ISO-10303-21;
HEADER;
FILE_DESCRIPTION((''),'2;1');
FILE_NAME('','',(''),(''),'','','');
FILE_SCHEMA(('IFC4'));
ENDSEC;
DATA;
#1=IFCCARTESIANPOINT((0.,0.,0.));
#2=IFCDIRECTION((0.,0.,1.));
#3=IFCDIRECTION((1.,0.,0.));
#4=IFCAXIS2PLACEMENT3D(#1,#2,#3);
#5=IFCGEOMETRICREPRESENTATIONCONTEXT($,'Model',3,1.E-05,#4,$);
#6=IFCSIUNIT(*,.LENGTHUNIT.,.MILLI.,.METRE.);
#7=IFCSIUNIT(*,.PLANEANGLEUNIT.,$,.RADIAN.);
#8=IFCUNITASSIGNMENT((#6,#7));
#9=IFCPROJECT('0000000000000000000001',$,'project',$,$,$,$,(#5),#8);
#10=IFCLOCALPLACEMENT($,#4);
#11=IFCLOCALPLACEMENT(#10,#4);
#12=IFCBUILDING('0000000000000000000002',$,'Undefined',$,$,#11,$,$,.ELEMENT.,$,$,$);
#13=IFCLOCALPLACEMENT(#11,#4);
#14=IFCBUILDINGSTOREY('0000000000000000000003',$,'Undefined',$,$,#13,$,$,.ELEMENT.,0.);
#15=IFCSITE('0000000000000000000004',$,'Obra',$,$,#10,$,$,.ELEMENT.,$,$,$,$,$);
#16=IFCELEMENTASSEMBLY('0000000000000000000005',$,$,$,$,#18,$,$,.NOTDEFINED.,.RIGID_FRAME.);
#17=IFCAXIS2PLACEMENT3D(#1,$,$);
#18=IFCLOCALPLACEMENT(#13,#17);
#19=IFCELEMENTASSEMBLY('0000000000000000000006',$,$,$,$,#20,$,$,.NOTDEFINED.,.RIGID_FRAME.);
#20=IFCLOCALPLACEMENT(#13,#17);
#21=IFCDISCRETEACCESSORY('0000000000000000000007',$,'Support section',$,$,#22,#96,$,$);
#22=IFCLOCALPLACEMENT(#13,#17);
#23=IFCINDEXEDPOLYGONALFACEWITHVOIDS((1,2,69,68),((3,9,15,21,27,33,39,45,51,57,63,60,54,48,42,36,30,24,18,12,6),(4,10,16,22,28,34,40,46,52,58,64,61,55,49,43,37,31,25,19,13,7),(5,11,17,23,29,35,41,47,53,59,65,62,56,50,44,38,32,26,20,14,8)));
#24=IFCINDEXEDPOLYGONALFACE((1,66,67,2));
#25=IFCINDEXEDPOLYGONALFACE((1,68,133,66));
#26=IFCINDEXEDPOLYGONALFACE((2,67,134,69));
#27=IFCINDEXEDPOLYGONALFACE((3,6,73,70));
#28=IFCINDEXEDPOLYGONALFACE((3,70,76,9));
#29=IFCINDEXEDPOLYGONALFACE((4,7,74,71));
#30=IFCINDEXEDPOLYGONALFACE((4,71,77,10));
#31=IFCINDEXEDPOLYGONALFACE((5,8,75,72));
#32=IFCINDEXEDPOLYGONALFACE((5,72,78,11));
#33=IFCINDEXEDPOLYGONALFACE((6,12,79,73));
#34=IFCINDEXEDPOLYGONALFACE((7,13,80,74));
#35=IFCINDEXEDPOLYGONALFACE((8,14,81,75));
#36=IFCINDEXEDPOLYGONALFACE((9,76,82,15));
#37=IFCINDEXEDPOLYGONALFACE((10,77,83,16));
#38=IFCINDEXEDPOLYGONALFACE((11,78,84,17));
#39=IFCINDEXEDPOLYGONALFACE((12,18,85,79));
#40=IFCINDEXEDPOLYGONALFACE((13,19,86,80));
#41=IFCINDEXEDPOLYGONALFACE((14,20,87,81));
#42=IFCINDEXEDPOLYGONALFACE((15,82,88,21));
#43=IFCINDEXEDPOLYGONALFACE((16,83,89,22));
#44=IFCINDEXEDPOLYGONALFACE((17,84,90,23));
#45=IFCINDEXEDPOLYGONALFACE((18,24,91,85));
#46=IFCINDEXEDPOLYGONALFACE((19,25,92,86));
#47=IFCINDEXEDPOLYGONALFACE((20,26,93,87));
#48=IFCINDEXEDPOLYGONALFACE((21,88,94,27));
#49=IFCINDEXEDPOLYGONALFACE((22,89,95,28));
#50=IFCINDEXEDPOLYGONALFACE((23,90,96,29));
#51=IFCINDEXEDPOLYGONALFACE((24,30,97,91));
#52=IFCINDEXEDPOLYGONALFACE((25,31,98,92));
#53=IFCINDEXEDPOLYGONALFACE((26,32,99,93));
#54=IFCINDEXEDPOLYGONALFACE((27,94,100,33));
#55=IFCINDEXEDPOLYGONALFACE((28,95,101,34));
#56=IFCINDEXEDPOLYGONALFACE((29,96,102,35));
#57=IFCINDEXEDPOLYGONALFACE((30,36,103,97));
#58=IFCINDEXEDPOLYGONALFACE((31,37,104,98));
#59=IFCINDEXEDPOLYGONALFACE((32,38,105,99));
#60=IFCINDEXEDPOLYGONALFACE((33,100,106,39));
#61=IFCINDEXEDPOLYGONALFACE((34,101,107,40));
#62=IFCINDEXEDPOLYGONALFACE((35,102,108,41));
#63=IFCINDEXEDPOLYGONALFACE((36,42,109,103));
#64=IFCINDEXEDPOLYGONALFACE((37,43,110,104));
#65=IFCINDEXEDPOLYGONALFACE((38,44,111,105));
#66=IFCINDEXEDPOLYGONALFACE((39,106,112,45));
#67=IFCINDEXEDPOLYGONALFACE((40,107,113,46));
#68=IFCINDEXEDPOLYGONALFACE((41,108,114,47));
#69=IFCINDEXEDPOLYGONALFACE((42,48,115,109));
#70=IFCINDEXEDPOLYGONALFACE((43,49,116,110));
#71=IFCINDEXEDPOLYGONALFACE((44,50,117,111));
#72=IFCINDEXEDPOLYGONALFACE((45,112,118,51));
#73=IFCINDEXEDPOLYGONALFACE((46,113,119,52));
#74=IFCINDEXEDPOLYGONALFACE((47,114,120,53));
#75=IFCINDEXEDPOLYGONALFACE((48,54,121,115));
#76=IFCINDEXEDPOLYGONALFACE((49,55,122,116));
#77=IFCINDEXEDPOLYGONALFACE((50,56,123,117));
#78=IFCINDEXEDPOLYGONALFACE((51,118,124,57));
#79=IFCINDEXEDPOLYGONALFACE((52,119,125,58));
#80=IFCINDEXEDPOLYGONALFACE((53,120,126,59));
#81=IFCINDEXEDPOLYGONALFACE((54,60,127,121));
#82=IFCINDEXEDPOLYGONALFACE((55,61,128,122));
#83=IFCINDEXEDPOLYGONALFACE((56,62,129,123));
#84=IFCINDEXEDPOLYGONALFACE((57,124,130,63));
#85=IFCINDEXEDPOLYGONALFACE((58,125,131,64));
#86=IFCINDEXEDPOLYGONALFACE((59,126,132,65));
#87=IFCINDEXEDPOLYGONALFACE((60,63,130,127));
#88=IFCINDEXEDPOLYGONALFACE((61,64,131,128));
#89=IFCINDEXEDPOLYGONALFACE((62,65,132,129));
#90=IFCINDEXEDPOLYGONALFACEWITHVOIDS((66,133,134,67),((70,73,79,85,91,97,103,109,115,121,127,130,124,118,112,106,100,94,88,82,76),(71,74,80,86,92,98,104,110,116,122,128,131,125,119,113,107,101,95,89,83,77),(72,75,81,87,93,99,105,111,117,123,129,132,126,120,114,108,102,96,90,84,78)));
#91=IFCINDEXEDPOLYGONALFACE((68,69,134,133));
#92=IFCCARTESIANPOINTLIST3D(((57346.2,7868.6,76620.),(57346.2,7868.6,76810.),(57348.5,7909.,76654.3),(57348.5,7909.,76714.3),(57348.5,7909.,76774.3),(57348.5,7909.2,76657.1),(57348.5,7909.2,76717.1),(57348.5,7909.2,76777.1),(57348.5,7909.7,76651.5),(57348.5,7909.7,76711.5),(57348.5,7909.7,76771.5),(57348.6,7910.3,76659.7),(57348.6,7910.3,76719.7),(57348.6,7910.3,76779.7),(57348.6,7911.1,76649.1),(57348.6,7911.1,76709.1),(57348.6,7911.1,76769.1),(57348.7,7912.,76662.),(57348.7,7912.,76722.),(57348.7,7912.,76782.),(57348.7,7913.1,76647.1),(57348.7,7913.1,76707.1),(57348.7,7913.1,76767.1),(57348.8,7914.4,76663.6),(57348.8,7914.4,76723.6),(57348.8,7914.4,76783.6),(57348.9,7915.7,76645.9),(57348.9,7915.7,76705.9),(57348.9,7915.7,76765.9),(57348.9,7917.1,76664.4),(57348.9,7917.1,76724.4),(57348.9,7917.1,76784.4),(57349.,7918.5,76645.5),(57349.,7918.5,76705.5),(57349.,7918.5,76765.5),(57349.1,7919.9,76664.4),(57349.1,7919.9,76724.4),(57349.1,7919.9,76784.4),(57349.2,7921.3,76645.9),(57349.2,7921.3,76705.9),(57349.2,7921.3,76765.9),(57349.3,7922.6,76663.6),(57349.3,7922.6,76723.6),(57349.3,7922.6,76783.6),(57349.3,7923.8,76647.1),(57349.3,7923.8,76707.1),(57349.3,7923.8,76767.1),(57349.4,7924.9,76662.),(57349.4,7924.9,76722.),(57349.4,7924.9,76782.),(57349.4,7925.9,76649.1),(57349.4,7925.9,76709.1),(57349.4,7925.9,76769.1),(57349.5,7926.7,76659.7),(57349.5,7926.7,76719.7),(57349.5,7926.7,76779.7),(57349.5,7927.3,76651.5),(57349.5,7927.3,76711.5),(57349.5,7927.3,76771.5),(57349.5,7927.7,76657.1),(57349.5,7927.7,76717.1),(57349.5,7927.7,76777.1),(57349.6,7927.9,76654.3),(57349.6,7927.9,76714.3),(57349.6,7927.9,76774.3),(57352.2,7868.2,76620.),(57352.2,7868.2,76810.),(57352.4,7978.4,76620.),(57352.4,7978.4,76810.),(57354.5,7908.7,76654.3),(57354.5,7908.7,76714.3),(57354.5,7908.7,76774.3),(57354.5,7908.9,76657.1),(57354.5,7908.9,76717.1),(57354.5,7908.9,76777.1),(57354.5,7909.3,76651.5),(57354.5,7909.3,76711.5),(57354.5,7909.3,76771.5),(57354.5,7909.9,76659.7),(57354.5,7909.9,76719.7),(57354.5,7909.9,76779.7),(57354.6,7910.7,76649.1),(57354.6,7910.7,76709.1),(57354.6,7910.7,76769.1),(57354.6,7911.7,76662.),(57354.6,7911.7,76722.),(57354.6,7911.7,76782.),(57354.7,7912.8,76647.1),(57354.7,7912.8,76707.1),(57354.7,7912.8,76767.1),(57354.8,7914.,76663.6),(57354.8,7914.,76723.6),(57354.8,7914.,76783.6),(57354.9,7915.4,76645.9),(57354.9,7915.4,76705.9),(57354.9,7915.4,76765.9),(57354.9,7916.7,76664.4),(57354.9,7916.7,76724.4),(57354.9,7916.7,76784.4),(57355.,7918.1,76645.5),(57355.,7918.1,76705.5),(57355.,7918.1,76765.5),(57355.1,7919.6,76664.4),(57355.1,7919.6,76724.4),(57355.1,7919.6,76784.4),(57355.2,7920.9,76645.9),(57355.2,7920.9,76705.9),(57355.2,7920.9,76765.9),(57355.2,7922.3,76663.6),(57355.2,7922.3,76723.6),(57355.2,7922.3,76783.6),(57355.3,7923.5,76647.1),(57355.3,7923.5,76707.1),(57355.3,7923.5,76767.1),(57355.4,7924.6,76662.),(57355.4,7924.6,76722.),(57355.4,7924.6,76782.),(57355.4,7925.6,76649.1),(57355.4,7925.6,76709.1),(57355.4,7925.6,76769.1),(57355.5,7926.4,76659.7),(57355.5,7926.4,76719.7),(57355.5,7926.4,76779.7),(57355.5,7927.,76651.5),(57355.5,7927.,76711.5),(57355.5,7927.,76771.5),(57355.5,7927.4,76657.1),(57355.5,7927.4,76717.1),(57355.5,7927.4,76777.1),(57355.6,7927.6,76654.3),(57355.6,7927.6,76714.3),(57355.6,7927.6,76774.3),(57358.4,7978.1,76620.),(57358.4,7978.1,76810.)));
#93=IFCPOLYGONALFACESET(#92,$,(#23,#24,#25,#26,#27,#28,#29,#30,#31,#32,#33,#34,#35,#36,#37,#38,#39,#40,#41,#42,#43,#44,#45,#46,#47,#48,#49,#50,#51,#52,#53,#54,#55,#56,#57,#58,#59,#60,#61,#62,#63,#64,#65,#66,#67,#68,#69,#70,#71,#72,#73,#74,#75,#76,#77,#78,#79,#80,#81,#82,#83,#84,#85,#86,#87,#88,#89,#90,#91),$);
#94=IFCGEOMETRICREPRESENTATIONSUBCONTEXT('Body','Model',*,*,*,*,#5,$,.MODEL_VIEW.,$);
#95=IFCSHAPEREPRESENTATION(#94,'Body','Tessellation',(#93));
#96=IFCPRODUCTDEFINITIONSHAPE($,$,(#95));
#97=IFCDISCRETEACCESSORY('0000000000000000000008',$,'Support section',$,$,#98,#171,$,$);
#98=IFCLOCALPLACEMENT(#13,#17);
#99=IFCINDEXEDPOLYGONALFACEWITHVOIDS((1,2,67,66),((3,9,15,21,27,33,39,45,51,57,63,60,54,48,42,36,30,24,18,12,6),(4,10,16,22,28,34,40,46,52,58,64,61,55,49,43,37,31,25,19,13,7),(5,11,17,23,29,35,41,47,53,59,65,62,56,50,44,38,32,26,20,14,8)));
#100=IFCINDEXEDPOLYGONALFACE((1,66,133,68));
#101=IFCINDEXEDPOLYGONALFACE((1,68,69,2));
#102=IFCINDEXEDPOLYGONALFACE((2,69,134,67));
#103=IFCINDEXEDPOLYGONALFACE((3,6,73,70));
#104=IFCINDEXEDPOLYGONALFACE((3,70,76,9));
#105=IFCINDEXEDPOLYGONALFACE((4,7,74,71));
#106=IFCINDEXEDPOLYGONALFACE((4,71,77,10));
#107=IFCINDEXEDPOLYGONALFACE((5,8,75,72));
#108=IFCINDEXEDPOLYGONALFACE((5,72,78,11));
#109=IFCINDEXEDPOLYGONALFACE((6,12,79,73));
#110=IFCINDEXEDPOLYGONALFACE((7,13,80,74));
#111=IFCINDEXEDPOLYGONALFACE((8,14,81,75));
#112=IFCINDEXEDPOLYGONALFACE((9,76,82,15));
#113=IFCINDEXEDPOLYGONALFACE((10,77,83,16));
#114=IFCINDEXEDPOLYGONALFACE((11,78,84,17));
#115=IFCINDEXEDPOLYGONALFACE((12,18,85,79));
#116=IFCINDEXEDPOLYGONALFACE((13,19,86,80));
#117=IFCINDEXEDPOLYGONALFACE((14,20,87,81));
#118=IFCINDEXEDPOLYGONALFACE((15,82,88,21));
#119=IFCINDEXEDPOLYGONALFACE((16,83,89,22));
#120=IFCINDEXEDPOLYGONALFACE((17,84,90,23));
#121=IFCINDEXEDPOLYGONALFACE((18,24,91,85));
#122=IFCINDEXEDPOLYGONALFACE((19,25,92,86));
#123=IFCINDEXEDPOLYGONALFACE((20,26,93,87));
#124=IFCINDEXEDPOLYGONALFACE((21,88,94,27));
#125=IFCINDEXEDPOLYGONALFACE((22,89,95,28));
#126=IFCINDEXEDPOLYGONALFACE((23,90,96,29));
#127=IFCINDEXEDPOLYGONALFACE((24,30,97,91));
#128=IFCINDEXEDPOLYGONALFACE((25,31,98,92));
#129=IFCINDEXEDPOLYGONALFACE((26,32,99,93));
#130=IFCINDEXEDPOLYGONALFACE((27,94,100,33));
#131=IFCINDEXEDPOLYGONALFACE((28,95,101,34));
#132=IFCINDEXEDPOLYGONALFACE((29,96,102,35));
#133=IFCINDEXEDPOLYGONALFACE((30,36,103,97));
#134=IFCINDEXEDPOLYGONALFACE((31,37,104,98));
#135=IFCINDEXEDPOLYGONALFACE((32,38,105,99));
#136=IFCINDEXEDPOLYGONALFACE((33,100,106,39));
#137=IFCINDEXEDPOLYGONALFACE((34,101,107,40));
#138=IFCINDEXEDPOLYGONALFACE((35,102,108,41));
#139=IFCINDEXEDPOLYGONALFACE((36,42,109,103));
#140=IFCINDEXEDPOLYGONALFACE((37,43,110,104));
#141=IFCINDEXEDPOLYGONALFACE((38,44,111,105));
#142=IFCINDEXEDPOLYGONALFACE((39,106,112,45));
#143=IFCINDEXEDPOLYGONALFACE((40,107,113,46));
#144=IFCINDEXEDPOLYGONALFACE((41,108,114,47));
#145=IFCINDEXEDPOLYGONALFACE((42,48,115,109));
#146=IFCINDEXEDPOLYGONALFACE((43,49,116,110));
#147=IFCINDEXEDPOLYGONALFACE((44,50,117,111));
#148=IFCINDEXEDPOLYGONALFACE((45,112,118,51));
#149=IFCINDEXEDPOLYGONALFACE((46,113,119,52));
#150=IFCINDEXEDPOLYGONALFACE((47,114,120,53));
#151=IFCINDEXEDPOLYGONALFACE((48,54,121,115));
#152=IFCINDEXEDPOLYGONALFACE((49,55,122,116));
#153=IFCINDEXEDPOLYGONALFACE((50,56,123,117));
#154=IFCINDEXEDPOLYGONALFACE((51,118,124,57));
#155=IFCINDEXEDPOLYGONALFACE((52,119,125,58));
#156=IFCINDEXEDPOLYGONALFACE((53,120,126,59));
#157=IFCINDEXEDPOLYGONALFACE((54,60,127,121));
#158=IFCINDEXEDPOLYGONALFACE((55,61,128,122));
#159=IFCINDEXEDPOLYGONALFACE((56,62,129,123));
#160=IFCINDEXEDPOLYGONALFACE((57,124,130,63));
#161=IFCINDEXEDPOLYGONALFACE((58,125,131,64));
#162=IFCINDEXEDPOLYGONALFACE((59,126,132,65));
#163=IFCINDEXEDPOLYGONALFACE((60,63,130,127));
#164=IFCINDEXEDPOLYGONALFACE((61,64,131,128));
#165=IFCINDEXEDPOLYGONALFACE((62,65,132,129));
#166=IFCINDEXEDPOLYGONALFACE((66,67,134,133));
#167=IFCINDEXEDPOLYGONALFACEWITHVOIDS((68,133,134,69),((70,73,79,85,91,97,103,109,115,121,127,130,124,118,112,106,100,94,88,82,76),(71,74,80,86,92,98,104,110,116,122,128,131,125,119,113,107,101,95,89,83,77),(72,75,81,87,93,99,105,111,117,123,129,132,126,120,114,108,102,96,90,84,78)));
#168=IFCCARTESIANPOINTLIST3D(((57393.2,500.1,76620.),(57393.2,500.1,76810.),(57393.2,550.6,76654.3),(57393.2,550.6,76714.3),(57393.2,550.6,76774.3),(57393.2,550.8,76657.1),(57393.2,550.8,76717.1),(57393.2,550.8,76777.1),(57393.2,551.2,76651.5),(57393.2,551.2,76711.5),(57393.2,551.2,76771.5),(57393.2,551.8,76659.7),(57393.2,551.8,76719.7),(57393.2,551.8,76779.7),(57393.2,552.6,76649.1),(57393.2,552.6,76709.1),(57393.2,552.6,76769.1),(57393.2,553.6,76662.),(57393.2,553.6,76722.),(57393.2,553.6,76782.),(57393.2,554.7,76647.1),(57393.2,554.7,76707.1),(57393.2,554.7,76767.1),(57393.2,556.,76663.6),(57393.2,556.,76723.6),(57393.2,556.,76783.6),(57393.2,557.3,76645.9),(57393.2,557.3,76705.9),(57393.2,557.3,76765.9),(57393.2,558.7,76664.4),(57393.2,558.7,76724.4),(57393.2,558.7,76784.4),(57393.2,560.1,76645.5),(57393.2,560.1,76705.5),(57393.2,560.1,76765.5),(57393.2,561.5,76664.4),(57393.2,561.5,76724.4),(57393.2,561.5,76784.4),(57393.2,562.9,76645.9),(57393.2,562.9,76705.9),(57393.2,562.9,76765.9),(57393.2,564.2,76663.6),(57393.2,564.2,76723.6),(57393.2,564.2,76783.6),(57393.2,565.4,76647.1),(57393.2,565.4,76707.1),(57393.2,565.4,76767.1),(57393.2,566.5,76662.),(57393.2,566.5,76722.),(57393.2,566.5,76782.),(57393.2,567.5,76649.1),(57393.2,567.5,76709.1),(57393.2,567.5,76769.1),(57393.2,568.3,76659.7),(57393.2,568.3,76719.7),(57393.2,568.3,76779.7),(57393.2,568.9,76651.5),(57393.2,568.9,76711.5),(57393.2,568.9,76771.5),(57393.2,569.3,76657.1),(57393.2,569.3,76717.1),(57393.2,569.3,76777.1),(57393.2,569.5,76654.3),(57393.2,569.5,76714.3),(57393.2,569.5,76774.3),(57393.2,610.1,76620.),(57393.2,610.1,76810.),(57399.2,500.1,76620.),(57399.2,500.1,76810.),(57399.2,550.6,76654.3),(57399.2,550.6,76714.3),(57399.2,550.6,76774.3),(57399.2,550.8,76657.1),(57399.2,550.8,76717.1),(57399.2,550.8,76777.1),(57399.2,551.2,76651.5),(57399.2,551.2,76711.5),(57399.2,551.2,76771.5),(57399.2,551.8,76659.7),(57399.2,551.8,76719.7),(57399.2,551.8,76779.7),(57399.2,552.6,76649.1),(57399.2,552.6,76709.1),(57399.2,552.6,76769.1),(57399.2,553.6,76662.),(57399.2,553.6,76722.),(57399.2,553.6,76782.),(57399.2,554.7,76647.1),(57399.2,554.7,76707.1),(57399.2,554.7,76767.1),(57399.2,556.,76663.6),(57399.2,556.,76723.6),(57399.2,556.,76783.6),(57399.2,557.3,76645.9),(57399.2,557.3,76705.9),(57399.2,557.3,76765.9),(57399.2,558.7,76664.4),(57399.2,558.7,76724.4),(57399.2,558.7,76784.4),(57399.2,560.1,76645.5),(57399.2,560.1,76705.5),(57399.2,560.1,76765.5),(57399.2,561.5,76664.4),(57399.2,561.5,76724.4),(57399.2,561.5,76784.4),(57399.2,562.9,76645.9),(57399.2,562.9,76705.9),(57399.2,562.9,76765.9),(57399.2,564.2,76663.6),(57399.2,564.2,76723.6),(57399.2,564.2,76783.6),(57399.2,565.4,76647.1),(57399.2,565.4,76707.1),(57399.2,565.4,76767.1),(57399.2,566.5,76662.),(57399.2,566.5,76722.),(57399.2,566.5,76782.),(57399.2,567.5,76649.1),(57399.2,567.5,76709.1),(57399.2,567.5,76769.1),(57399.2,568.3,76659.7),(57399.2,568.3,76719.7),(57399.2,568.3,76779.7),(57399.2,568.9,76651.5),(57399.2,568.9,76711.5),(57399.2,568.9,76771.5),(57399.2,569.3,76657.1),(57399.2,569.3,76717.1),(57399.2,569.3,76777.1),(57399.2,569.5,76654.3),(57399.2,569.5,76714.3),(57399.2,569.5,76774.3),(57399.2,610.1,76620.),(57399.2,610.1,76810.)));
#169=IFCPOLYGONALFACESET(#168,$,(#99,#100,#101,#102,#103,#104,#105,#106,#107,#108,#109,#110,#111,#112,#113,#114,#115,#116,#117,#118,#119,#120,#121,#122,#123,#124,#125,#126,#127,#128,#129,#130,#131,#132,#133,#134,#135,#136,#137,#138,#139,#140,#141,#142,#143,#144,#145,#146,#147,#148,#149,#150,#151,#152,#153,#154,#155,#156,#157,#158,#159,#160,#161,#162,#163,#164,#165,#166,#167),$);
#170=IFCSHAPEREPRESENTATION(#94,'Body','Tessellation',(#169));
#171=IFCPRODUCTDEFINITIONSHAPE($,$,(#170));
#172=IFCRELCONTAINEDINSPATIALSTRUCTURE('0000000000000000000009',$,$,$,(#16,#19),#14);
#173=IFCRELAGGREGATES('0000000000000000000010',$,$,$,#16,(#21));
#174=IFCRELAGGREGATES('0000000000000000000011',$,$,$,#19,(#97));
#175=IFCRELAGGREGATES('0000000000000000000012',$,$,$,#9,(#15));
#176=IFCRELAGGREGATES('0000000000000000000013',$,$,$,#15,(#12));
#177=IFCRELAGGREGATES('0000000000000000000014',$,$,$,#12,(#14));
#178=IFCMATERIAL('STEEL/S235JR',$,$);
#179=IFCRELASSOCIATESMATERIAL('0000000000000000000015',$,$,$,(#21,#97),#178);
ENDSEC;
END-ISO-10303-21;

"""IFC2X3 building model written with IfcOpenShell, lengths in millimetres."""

from ifc_helpers import new_model, si_unit, frame, origin_with_axes, origin_2d_with_axis, place, context, subcontext, project, spatial, rectangle, circle, extrude, source, transform, mapped, material, element, aggregate, save


model = new_model("IFC2X3")

# Units and contexts
model_context = context("Model", 3, precision=1e-05, world=origin_with_axes())
body_context = subcontext(model_context, "Body", "Model", "MODEL_VIEW")
ifc_project = project(units=[si_unit("LENGTHUNIT", "METRE", prefix="MILLI"), si_unit("PLANEANGLEUNIT", "RADIAN")], contexts=[model_context])

# Site, building, storey
site_placement = place(None, origin_with_axes())
site = spatial("IfcSite", under=ifc_project, at=site_placement, Name="Obra", CompositionType="ELEMENT")
building_placement = place(site_placement, origin_with_axes())
building = spatial("IfcBuilding", under=site, at=building_placement, Name="Undefined", CompositionType="ELEMENT")
storey_placement = place(building_placement, origin_with_axes())
storey = spatial("IfcBuildingStorey", under=building, at=storey_placement, Name="Undefined", CompositionType="ELEMENT", Elevation=0.0)

# Element assemblies
ifc_material_1 = material(Name="STEEL/S235JR")
assembly_1_placement = place(storey_placement, origin_with_axes())
assembly_1 = element("IfcElementAssembly", 1, at=assembly_1_placement, inside=storey, AssemblyPlace="NOTDEFINED", PredefinedType="RIGID_FRAME")
assembly_2_placement = place(storey_placement, origin_with_axes())
assembly_2 = element("IfcElementAssembly", 2, at=assembly_2_placement, inside=storey, AssemblyPlace="NOTDEFINED", PredefinedType="RIGID_FRAME")

# Shared definitions
shared_shape_1 = source(origin_with_axes(), body_context, "Body", "SweptSolid", [
    extrude(circle(Radius=9.5, at=origin_2d_with_axis()), frame((0.0, -9.2, 0.0), z_axis=(0.0, 1.0, 0.0), x_axis=(1.0, 0.0, 0.0)), (0.0, 0.0, 1.0), 6.2),
])

# Discrete accessories, openings
discrete_accessory_1_placement = place(assembly_1_placement, frame((57352.3, 7923.3, 76620.0), z_axis=(0.0, 0.0, 1.0), x_axis=(0.05711, 0.998368, 0.0)))
discrete_accessory_1 = element("IfcDiscreteAccessory", 3, at=discrete_accessory_1_placement, material=ifc_material_1, Name="Support section", context=body_context, shape_type="SweptSolid", body=[
    extrude(rectangle(XDim=6.0, YDim=110.0, at=origin_2d_with_axis()), frame((0.0, 0.0, 190.0), z_axis=(0.0, 0.0, -1.0), x_axis=(0.0, 1.0, 0.0)), (0.0, 0.0, 1.0), 190.0),
])
opening_1_placement = place(assembly_1_placement, frame((57361.0, 7967.9, 76835.0), z_axis=(-0.05711, -0.998368, 0.0), x_axis=(0.0, 0.0, -1.0)))
element("IfcOpeningElement", 4, at=opening_1_placement, cuts=discrete_accessory_1, ObjectType="Opening", context=body_context, shape_type="MappedRepresentation", body=[
    mapped(shared_shape_1, transform((60.0, 0.0, 50.0))),
    mapped(shared_shape_1, transform((120.0, 0.0, 50.0))),
    mapped(shared_shape_1, transform((180.0, 0.0, 50.0))),
])
aggregate(assembly_1, [discrete_accessory_1])
discrete_accessory_2_placement = place(assembly_2_placement, frame((57396.2, 555.1, 76620.0), z_axis=(0.0, 0.0, 1.0), x_axis=(0.000002, -1.0, 0.0)))
discrete_accessory_2 = element("IfcDiscreteAccessory", 5, at=discrete_accessory_2_placement, material=ifc_material_1, Name="Support section", context=body_context, shape_type="SweptSolid", body=[
    extrude(rectangle(XDim=6.0, YDim=110.0, at=origin_2d_with_axis()), frame((0.0, 0.0, 190.0), z_axis=(0.0, 0.0, -1.0), x_axis=(0.0, 1.0, 0.0)), (0.0, 0.0, 1.0), 190.0),
])
opening_2_placement = place(assembly_2_placement, frame((57390.1, 510.1, 76835.0), z_axis=(-0.000002, 1.0, 0.0), x_axis=(0.0, 0.0, -1.0)))
element("IfcOpeningElement", 6, at=opening_2_placement, cuts=discrete_accessory_2, ObjectType="Opening", context=body_context, shape_type="MappedRepresentation", body=[
    mapped(shared_shape_1, transform((60.0, 0.0, 50.0))),
    mapped(shared_shape_1, transform((120.0, 0.0, 50.0))),
    mapped(shared_shape_1, transform((180.0, 0.0, 50.0))),
])
aggregate(assembly_2, [discrete_accessory_2])

save(model, "model.ifc")
